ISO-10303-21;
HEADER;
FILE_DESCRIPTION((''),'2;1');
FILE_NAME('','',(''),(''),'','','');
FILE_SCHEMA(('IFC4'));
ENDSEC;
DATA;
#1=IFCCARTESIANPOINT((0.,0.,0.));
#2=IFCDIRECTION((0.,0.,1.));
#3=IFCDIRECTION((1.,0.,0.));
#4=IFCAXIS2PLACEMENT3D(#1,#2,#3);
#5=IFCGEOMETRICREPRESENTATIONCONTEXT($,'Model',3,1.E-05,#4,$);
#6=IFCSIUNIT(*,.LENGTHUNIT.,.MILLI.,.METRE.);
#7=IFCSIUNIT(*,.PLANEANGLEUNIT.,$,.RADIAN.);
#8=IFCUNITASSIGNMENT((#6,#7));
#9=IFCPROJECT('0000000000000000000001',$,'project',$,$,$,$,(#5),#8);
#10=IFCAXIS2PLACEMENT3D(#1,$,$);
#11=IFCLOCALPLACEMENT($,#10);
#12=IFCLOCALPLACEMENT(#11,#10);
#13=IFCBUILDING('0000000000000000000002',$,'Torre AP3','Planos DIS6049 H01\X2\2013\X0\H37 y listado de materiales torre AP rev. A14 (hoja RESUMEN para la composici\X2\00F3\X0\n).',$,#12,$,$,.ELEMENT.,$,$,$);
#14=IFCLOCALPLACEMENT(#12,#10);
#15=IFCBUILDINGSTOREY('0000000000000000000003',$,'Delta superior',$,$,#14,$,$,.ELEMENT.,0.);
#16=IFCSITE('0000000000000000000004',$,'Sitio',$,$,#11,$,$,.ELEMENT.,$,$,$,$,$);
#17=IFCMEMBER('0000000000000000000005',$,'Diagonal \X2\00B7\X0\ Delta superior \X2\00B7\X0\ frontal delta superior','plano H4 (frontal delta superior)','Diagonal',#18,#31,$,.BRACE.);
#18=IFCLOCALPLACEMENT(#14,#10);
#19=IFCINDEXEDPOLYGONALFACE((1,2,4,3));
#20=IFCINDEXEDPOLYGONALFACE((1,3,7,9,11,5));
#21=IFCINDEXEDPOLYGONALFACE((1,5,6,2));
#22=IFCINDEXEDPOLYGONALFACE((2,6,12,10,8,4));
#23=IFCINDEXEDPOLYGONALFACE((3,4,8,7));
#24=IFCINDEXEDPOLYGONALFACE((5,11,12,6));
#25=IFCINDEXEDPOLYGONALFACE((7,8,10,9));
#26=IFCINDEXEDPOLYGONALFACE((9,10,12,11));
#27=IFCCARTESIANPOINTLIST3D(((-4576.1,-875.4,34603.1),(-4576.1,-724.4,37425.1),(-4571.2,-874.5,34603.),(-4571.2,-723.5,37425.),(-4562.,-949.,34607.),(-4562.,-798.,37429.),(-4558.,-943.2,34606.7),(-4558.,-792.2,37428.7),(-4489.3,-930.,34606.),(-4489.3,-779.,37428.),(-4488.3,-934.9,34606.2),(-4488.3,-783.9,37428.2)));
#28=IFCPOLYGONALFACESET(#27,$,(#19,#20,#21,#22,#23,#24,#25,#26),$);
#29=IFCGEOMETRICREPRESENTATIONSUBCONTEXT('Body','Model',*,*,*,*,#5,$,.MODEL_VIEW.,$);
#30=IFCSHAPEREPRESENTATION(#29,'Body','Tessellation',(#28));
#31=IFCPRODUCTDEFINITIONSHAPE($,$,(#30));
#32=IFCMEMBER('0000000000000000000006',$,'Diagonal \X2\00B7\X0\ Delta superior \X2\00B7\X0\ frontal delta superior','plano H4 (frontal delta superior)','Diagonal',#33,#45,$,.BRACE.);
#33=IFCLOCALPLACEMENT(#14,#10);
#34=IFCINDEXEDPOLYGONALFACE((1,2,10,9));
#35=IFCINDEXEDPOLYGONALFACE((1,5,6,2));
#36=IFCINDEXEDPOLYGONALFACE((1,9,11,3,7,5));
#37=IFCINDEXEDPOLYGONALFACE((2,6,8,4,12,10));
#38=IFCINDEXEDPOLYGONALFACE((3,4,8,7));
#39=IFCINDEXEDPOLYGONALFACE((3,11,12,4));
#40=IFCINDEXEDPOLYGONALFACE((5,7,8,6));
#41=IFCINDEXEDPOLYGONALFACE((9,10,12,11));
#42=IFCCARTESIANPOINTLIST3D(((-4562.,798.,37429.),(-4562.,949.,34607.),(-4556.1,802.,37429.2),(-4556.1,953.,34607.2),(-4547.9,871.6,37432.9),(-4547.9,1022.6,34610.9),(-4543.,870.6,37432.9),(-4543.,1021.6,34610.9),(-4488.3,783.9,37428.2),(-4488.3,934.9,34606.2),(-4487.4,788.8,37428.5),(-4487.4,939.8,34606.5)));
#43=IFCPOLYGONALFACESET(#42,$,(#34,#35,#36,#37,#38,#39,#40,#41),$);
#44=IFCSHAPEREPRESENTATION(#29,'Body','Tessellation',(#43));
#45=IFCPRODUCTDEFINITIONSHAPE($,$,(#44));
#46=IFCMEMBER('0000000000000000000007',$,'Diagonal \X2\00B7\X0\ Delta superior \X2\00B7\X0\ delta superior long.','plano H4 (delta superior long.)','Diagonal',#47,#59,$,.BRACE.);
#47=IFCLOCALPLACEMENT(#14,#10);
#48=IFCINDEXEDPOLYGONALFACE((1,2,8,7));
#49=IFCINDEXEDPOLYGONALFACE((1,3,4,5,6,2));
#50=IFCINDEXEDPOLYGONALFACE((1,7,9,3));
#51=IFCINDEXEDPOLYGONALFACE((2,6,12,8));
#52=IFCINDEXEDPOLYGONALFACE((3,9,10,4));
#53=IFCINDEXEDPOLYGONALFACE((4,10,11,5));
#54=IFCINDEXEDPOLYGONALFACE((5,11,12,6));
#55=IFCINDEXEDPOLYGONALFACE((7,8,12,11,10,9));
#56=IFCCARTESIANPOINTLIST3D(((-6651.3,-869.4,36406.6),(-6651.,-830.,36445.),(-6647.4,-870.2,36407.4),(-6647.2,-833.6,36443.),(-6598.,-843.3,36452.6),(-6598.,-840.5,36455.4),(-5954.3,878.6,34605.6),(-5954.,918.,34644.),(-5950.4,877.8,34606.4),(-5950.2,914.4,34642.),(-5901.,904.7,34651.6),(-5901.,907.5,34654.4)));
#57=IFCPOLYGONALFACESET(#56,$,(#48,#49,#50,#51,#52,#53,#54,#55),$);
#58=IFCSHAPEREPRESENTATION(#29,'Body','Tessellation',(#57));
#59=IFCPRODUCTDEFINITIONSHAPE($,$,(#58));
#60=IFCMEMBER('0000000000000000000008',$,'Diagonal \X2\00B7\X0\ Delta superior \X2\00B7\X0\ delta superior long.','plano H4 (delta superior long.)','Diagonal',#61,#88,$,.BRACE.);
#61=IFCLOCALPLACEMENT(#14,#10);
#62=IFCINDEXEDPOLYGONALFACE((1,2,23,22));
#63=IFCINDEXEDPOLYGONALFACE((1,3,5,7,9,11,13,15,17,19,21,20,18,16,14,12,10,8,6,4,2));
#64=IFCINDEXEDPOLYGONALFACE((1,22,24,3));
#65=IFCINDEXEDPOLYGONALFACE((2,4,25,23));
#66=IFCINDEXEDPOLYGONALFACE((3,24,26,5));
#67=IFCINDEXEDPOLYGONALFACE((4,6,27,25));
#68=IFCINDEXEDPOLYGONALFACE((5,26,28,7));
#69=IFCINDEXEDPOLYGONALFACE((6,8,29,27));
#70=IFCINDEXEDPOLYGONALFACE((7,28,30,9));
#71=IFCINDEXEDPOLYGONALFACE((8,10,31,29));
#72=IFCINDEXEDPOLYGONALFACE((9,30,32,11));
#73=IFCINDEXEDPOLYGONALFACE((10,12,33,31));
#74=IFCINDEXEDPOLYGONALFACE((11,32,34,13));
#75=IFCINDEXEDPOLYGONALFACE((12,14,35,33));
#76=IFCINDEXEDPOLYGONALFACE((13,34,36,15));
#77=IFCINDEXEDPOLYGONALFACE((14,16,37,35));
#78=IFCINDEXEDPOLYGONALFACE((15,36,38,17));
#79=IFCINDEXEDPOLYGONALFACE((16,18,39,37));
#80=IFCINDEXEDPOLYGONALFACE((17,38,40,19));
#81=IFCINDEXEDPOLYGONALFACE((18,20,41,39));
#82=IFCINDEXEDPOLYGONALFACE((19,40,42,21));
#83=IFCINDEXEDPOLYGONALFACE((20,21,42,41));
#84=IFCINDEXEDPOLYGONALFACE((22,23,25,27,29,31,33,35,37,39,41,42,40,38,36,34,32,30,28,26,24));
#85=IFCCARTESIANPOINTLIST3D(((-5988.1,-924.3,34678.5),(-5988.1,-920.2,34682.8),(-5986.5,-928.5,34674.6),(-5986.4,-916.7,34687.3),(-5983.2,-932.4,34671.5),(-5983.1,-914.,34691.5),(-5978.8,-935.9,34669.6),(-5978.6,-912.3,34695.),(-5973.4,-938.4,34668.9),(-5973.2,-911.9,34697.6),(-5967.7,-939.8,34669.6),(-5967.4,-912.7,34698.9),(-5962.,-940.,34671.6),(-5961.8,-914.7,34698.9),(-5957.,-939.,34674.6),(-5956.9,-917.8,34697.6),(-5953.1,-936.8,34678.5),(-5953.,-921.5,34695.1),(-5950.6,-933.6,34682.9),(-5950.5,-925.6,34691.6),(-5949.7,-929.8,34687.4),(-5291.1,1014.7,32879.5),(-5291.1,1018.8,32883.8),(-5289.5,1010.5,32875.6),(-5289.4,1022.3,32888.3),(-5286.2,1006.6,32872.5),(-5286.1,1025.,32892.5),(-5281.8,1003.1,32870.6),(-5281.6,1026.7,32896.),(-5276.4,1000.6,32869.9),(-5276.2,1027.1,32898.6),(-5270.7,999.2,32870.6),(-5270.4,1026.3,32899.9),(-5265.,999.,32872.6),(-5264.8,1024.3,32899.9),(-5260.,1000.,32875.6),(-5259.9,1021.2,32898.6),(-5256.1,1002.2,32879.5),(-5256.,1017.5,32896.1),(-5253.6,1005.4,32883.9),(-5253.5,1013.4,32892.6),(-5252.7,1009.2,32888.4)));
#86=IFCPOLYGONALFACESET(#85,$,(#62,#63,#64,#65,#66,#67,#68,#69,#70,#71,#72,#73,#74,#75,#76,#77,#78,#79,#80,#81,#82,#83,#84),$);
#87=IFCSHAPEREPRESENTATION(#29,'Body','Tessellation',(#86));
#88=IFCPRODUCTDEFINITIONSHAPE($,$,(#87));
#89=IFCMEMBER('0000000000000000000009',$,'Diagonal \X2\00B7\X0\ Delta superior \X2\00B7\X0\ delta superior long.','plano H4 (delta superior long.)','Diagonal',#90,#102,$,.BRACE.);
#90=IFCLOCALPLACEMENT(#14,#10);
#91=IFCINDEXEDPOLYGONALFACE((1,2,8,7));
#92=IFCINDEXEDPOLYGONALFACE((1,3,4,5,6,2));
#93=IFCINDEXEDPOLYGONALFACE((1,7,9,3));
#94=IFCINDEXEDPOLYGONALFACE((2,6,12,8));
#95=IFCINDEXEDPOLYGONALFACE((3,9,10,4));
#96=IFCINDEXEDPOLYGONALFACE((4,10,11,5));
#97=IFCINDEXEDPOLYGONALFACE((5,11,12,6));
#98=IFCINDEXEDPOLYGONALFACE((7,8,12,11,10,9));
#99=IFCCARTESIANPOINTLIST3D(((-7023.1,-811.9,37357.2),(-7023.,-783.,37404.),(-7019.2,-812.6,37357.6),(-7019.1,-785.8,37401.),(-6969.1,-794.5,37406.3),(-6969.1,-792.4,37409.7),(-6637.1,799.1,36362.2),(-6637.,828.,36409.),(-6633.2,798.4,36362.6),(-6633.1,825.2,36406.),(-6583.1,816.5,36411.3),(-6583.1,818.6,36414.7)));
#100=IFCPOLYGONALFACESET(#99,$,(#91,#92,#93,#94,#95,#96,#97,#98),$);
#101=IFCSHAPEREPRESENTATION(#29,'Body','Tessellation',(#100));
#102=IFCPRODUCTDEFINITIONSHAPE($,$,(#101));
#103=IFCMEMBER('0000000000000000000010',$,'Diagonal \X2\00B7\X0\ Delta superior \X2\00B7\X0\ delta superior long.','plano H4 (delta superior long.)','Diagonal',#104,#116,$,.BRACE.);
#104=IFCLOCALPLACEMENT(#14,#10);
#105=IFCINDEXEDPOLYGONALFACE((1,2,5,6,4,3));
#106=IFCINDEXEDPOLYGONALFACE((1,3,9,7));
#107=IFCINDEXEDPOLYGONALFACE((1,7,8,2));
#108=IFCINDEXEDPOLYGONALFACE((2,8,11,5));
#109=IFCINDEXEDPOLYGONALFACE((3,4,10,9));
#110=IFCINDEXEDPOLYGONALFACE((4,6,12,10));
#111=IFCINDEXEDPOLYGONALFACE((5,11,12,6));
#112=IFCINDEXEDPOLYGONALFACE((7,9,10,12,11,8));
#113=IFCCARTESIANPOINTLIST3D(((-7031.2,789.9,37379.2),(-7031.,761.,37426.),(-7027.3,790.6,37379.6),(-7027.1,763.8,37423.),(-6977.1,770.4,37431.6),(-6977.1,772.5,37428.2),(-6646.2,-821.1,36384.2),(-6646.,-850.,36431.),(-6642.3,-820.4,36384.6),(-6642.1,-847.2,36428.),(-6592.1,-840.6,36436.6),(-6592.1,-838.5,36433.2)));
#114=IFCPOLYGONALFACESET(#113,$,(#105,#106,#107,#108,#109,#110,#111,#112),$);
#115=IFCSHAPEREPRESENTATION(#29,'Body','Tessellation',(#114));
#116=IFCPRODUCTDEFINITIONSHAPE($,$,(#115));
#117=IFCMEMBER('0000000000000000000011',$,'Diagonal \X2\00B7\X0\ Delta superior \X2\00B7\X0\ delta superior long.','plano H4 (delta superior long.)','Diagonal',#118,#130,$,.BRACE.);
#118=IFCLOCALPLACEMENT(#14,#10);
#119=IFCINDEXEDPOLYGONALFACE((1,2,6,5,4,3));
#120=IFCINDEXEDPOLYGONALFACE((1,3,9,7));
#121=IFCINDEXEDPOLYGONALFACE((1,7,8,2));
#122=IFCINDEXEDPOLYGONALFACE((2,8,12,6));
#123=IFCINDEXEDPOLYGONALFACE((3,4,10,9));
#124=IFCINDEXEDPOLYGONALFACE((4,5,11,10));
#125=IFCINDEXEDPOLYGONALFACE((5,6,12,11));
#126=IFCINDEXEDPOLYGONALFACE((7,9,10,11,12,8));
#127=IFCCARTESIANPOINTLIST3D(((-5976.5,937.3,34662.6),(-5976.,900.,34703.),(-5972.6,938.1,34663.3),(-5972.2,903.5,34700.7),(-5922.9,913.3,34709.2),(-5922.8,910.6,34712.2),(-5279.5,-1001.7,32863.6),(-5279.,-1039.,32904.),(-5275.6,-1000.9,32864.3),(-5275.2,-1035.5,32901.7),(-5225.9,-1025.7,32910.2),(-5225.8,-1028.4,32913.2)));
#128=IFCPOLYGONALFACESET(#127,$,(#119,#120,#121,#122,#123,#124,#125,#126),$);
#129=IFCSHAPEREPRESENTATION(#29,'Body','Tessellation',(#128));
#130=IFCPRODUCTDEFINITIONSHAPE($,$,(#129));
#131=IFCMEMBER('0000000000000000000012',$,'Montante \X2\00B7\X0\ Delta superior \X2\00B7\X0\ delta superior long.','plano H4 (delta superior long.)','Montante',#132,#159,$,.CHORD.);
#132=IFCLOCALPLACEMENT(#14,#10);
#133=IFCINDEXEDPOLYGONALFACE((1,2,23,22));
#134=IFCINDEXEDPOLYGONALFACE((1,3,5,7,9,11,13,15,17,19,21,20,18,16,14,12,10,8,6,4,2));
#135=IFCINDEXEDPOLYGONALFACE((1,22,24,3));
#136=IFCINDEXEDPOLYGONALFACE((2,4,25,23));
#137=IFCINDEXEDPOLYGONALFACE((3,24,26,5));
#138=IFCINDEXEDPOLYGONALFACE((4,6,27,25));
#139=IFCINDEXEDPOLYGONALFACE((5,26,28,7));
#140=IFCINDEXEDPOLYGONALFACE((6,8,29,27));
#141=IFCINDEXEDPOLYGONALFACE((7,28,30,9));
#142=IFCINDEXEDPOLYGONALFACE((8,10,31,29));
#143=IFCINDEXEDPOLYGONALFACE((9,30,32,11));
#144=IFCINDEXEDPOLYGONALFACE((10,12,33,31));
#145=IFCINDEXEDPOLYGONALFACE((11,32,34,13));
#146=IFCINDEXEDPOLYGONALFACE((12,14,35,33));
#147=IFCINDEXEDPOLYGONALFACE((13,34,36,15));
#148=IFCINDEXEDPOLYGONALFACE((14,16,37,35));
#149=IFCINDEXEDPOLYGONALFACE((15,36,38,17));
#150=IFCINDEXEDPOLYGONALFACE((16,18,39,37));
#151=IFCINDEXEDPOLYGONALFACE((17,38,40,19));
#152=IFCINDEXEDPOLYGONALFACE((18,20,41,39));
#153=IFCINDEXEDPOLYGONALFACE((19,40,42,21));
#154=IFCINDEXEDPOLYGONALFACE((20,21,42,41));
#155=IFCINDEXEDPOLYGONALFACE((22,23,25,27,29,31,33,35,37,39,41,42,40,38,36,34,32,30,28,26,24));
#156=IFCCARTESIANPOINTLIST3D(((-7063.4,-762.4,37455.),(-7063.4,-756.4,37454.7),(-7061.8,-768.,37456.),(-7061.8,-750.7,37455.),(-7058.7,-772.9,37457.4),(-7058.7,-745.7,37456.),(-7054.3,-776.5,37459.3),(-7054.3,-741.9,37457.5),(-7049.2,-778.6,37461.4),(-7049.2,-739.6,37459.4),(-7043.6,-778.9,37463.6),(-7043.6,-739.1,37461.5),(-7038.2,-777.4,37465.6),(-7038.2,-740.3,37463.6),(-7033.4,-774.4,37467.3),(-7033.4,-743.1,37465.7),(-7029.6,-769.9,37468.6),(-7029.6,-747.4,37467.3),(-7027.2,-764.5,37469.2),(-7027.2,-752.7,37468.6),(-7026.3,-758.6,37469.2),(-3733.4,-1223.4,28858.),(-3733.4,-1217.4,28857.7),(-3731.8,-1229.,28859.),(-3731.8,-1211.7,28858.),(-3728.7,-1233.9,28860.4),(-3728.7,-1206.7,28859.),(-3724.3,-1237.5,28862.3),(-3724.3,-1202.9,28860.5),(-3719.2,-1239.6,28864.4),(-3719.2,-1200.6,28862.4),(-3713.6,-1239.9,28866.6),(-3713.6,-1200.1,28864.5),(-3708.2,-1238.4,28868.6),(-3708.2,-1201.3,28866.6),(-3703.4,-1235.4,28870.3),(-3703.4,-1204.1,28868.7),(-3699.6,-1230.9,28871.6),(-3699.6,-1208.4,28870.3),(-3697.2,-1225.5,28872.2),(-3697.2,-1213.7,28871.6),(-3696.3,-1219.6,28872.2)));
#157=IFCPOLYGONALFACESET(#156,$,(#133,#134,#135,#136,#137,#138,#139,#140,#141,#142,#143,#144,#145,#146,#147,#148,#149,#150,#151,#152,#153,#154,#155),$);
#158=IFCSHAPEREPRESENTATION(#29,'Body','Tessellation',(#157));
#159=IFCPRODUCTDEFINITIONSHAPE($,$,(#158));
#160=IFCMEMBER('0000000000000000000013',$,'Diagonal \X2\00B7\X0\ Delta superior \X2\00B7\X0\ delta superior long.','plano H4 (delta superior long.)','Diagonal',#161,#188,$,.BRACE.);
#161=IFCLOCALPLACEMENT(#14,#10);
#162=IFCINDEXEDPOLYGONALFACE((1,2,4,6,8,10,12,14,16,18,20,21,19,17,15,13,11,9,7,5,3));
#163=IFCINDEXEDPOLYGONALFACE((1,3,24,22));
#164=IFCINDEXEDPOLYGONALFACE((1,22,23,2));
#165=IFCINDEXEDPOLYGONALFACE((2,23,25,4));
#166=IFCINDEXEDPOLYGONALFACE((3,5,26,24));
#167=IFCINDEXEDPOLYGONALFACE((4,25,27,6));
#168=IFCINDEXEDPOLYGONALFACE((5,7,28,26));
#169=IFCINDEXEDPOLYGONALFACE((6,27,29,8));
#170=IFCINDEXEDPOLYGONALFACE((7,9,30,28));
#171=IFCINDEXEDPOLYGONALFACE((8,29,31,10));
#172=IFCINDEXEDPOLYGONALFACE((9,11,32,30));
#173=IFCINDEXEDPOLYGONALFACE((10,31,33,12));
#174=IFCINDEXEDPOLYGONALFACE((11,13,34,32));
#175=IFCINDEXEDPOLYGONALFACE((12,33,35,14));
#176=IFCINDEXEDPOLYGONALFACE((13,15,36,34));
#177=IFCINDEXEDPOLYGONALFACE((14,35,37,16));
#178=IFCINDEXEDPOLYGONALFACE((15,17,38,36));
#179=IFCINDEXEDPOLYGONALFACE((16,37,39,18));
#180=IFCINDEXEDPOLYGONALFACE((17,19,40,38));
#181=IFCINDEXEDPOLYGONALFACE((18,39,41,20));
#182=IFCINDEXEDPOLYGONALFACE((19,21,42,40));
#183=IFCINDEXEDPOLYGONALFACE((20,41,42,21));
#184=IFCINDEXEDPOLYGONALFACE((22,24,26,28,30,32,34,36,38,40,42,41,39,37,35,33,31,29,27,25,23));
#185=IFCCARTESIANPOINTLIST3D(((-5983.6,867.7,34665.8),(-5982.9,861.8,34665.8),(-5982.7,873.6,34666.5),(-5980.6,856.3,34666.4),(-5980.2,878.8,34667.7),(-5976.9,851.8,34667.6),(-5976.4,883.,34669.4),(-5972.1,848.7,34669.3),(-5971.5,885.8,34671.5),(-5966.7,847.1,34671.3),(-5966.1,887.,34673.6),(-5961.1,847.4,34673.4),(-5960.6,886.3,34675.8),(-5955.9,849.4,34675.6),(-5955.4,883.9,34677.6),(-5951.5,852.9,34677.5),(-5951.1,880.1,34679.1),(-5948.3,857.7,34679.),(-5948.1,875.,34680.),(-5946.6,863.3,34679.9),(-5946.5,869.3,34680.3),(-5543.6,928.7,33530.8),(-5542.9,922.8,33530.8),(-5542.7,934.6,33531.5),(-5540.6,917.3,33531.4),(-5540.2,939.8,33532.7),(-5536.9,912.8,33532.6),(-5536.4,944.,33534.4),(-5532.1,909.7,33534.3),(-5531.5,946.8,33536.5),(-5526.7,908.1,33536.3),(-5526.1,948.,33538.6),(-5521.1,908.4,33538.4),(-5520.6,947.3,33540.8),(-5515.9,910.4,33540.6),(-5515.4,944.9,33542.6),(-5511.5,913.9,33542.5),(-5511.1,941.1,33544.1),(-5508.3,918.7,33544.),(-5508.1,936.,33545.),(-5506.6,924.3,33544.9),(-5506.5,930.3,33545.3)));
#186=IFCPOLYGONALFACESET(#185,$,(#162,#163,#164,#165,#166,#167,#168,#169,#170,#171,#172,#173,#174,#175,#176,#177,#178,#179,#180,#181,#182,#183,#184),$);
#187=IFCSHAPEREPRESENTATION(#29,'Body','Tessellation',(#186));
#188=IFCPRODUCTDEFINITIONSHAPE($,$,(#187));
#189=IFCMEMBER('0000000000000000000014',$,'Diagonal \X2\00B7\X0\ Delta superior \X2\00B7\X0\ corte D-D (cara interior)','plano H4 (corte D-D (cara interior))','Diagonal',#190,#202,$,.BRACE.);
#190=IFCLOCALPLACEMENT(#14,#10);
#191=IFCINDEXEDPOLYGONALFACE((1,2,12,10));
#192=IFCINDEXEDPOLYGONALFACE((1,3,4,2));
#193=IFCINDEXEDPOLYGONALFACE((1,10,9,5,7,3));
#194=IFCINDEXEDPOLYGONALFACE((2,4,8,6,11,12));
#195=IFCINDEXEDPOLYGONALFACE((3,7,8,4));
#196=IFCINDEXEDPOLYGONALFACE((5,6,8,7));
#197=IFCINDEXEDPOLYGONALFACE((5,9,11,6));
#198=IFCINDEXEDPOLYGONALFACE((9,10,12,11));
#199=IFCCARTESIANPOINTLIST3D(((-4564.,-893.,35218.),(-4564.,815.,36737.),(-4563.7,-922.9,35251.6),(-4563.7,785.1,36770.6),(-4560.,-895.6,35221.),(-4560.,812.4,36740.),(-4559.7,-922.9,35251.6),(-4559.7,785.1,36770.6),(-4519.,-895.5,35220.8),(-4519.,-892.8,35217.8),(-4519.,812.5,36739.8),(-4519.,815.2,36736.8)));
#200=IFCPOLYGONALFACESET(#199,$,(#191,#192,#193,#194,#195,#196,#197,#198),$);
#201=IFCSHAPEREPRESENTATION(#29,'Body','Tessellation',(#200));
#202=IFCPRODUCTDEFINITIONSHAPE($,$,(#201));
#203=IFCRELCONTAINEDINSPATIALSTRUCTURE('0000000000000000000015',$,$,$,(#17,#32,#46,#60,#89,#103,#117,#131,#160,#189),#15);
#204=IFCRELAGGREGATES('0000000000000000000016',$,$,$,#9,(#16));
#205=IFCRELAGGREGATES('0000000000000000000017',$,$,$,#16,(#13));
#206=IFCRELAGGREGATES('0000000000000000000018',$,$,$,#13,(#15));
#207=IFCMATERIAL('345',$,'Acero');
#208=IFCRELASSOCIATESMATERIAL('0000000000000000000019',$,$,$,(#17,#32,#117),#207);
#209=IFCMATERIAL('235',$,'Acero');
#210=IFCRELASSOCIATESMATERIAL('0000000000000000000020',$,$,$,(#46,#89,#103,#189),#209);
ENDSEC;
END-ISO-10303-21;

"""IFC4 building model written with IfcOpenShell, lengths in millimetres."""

from ifc_helpers import new_model, si_unit, frame, frame_2d, origin, origin_with_axes, place, context, subcontext, project, spatial, circle, l_section, extrude, material, element, save


model = new_model("IFC4")

# Units and contexts
model_context = context("Model", 3, precision=1e-05, world=origin_with_axes())
body_context = subcontext(model_context, "Body", "Model", "MODEL_VIEW")
ifc_project = project(units=[si_unit("LENGTHUNIT", "METRE", prefix="MILLI"), si_unit("PLANEANGLEUNIT", "RADIAN")], contexts=[model_context])

# Site, building, storey
site_placement = place(None, origin())
site = spatial("IfcSite", under=ifc_project, at=site_placement, Name="Sitio", CompositionType="ELEMENT")
building_placement = place(site_placement, origin())
building = spatial("IfcBuilding", under=site, at=building_placement, Name="Torre AP3", Description="Planos DIS6049 H01–H37 y listado de materiales torre AP rev. A14 (hoja RESUMEN para la composición).", CompositionType="ELEMENT")
storey_placement = place(building_placement, origin())
storey = spatial("IfcBuildingStorey", under=building, at=storey_placement, Name="Delta superior", CompositionType="ELEMENT", Elevation=0.0)

# Members
ifc_material_1 = material(Name="235", Category="Acero")
ifc_material_2 = material(Name="345", Category="Acero")
for number, where, z_axis, x_axis, name in (
    (1, (-4562.0, -949.0, 34607.0), (0.0, 0.053432, 0.998572), (0.982208, 0.187529, -0.010034), "Diagonal · Delta superior · frontal delta superior"),
    (2, (-4562.0, 949.0, 34607.0), (0.0, -0.053432, 0.998572), (0.982208, -0.187529, -0.010034), "Diagonal · Delta superior · frontal delta superior"),
):
    element("IfcMember", number, at=place(storey_placement, frame(where, z_axis=z_axis, x_axis=x_axis)), inside=storey, material=ifc_material_2, Name=name, Description="plano H4 (frontal delta superior)", ObjectType="Diagonal", PredefinedType="BRACE", context=body_context, shape_type="SweptSolid", body=[
        extrude(l_section(Depth=75.0, Width=75.0, Thickness=5.0, at=frame_2d((37.5, 37.5))), None, (0.0, 0.0, 1.0), 2826.0),
    ])
member_1_placement = place(storey_placement, frame((-6651.0, -830.0, 36445.0), z_axis=(0.267584, 0.671072, -0.691419), x_axis=(0.963521, -0.190088, 0.188396)))
element("IfcMember", 3, at=member_1_placement, inside=storey, material=ifc_material_1, Name="Diagonal · Delta superior · delta superior long.", Description="plano H4 (delta superior long.)", ObjectType="Diagonal", PredefinedType="BRACE", context=body_context, shape_type="SweptSolid", body=[
    extrude(l_section(Depth=55.0, Width=55.0, Thickness=4.0, at=frame_2d((27.5, 27.5))), None, (0.0, 0.0, 1.0), 2604.8),
])
member_2_placement = place(storey_placement, frame((-5969.0, -926.0, 34684.0), z_axis=(0.254816, 0.708877, -0.657695), x_axis=(0.966975, -0.190493, 0.169325)))
element("IfcMember", 4, at=member_2_placement, inside=storey, Name="Diagonal · Delta superior · delta superior long.", Description="plano H4 (delta superior long.)", ObjectType="Diagonal", PredefinedType="BRACE", context=body_context, shape_type="SweptSolid", body=[
    extrude(circle(Radius=20.0), None, (0.0, 0.0, 1.0), 2735.3),
])
member_3_placement = place(storey_placement, frame((-7023.0, -783.0, 37404.0), z_axis=(0.199747, 0.833659, -0.514892), x_axis=(0.979846, -0.170873, 0.103461)))
element("IfcMember", 5, at=member_3_placement, inside=storey, material=ifc_material_1, Name="Diagonal · Delta superior · delta superior long.", Description="plano H4 (delta superior long.)", ObjectType="Diagonal", PredefinedType="BRACE", context=body_context, shape_type="SweptSolid", body=[
    extrude(l_section(Depth=55.0, Width=55.0, Thickness=4.0, at=frame_2d((27.5, 27.5))), None, (0.0, 0.0, 1.0), 1932.4),
])
member_4_placement = place(storey_placement, frame((-6646.0, -850.0, 36431.0), z_axis=(-0.19925, 0.833745, 0.514945), x_axis=(0.979943, 0.171353, 0.101736)))
element("IfcMember", 6, at=member_4_placement, inside=storey, material=ifc_material_1, Name="Diagonal · Delta superior · delta superior long.", Description="plano H4 (delta superior long.)", ObjectType="Diagonal", PredefinedType="BRACE", context=body_context, shape_type="SweptSolid", body=[
    extrude(l_section(Depth=55.0, Width=55.0, Thickness=4.0, at=frame_2d((27.5, 27.5))), None, (0.0, 0.0, 1.0), 1932.2),
])
member_5_placement = place(storey_placement, frame((-5279.0, -1039.0, 32904.0), z_axis=(-0.254816, 0.708877, 0.657695), x_axis=(0.966953, 0.192686, 0.166953)))
element("IfcMember", 7, at=member_5_placement, inside=storey, material=ifc_material_2, Name="Diagonal · Delta superior · delta superior long.", Description="plano H4 (delta superior long.)", ObjectType="Diagonal", PredefinedType="BRACE", context=body_context, shape_type="SweptSolid", body=[
    extrude(l_section(Depth=55.0, Width=55.0, Thickness=4.0, at=frame_2d((27.5, 27.5))), None, (0.0, 0.0, 1.0), 2735.3),
])
for number, where, z_axis, x_axis, name in (
    (8, (-3715.0, -1220.0, 28865.0), (-0.360744, 0.049941, 0.931327), (0.932665, 0.019317, 0.360227), "Montante · Delta superior · delta superior long."),
):
    element("IfcMember", number, at=place(storey_placement, frame(where, z_axis=z_axis, x_axis=x_axis)), inside=storey, Name=name, Description="plano H4 (delta superior long.)", ObjectType="Montante", PredefinedType="CHORD", context=body_context, shape_type="SweptSolid", body=[
        extrude(circle(Radius=20.0), None, (0.0, 0.0, 1.0), 9230.9),
    ])
member_6_placement = place(storey_placement, frame((-5525.0, 928.0, 33538.0), z_axis=(-0.361002, -0.050048, 0.931221), x_axis=(0.919866, -0.183339, 0.346747)))
element("IfcMember", 9, at=member_6_placement, inside=storey, Name="Diagonal · Delta superior · delta superior long.", Description="plano H4 (delta superior long.)", ObjectType="Diagonal", PredefinedType="BRACE", context=body_context, shape_type="SweptSolid", body=[
    extrude(circle(Radius=20.0), None, (0.0, 0.0, 1.0), 1218.8),
])
member_7_placement = place(storey_placement, frame((-4564.0, 815.0, 36737.0), z_axis=(0.0, -0.74724, -0.664554), x_axis=(0.999984, 0.003774, -0.004243)))
element("IfcMember", 10, at=member_7_placement, inside=storey, material=ifc_material_1, Name="Diagonal · Delta superior · corte D-D (cara interior)", Description="plano H4 (corte D-D (cara interior))", ObjectType="Diagonal", PredefinedType="BRACE", context=body_context, shape_type="SweptSolid", body=[
    extrude(l_section(Depth=45.0, Width=45.0, Thickness=4.0, at=frame_2d((22.5, 22.5))), None, (0.0, 0.0, 1.0), 2285.7),
])

save(model, "model.ifc")
